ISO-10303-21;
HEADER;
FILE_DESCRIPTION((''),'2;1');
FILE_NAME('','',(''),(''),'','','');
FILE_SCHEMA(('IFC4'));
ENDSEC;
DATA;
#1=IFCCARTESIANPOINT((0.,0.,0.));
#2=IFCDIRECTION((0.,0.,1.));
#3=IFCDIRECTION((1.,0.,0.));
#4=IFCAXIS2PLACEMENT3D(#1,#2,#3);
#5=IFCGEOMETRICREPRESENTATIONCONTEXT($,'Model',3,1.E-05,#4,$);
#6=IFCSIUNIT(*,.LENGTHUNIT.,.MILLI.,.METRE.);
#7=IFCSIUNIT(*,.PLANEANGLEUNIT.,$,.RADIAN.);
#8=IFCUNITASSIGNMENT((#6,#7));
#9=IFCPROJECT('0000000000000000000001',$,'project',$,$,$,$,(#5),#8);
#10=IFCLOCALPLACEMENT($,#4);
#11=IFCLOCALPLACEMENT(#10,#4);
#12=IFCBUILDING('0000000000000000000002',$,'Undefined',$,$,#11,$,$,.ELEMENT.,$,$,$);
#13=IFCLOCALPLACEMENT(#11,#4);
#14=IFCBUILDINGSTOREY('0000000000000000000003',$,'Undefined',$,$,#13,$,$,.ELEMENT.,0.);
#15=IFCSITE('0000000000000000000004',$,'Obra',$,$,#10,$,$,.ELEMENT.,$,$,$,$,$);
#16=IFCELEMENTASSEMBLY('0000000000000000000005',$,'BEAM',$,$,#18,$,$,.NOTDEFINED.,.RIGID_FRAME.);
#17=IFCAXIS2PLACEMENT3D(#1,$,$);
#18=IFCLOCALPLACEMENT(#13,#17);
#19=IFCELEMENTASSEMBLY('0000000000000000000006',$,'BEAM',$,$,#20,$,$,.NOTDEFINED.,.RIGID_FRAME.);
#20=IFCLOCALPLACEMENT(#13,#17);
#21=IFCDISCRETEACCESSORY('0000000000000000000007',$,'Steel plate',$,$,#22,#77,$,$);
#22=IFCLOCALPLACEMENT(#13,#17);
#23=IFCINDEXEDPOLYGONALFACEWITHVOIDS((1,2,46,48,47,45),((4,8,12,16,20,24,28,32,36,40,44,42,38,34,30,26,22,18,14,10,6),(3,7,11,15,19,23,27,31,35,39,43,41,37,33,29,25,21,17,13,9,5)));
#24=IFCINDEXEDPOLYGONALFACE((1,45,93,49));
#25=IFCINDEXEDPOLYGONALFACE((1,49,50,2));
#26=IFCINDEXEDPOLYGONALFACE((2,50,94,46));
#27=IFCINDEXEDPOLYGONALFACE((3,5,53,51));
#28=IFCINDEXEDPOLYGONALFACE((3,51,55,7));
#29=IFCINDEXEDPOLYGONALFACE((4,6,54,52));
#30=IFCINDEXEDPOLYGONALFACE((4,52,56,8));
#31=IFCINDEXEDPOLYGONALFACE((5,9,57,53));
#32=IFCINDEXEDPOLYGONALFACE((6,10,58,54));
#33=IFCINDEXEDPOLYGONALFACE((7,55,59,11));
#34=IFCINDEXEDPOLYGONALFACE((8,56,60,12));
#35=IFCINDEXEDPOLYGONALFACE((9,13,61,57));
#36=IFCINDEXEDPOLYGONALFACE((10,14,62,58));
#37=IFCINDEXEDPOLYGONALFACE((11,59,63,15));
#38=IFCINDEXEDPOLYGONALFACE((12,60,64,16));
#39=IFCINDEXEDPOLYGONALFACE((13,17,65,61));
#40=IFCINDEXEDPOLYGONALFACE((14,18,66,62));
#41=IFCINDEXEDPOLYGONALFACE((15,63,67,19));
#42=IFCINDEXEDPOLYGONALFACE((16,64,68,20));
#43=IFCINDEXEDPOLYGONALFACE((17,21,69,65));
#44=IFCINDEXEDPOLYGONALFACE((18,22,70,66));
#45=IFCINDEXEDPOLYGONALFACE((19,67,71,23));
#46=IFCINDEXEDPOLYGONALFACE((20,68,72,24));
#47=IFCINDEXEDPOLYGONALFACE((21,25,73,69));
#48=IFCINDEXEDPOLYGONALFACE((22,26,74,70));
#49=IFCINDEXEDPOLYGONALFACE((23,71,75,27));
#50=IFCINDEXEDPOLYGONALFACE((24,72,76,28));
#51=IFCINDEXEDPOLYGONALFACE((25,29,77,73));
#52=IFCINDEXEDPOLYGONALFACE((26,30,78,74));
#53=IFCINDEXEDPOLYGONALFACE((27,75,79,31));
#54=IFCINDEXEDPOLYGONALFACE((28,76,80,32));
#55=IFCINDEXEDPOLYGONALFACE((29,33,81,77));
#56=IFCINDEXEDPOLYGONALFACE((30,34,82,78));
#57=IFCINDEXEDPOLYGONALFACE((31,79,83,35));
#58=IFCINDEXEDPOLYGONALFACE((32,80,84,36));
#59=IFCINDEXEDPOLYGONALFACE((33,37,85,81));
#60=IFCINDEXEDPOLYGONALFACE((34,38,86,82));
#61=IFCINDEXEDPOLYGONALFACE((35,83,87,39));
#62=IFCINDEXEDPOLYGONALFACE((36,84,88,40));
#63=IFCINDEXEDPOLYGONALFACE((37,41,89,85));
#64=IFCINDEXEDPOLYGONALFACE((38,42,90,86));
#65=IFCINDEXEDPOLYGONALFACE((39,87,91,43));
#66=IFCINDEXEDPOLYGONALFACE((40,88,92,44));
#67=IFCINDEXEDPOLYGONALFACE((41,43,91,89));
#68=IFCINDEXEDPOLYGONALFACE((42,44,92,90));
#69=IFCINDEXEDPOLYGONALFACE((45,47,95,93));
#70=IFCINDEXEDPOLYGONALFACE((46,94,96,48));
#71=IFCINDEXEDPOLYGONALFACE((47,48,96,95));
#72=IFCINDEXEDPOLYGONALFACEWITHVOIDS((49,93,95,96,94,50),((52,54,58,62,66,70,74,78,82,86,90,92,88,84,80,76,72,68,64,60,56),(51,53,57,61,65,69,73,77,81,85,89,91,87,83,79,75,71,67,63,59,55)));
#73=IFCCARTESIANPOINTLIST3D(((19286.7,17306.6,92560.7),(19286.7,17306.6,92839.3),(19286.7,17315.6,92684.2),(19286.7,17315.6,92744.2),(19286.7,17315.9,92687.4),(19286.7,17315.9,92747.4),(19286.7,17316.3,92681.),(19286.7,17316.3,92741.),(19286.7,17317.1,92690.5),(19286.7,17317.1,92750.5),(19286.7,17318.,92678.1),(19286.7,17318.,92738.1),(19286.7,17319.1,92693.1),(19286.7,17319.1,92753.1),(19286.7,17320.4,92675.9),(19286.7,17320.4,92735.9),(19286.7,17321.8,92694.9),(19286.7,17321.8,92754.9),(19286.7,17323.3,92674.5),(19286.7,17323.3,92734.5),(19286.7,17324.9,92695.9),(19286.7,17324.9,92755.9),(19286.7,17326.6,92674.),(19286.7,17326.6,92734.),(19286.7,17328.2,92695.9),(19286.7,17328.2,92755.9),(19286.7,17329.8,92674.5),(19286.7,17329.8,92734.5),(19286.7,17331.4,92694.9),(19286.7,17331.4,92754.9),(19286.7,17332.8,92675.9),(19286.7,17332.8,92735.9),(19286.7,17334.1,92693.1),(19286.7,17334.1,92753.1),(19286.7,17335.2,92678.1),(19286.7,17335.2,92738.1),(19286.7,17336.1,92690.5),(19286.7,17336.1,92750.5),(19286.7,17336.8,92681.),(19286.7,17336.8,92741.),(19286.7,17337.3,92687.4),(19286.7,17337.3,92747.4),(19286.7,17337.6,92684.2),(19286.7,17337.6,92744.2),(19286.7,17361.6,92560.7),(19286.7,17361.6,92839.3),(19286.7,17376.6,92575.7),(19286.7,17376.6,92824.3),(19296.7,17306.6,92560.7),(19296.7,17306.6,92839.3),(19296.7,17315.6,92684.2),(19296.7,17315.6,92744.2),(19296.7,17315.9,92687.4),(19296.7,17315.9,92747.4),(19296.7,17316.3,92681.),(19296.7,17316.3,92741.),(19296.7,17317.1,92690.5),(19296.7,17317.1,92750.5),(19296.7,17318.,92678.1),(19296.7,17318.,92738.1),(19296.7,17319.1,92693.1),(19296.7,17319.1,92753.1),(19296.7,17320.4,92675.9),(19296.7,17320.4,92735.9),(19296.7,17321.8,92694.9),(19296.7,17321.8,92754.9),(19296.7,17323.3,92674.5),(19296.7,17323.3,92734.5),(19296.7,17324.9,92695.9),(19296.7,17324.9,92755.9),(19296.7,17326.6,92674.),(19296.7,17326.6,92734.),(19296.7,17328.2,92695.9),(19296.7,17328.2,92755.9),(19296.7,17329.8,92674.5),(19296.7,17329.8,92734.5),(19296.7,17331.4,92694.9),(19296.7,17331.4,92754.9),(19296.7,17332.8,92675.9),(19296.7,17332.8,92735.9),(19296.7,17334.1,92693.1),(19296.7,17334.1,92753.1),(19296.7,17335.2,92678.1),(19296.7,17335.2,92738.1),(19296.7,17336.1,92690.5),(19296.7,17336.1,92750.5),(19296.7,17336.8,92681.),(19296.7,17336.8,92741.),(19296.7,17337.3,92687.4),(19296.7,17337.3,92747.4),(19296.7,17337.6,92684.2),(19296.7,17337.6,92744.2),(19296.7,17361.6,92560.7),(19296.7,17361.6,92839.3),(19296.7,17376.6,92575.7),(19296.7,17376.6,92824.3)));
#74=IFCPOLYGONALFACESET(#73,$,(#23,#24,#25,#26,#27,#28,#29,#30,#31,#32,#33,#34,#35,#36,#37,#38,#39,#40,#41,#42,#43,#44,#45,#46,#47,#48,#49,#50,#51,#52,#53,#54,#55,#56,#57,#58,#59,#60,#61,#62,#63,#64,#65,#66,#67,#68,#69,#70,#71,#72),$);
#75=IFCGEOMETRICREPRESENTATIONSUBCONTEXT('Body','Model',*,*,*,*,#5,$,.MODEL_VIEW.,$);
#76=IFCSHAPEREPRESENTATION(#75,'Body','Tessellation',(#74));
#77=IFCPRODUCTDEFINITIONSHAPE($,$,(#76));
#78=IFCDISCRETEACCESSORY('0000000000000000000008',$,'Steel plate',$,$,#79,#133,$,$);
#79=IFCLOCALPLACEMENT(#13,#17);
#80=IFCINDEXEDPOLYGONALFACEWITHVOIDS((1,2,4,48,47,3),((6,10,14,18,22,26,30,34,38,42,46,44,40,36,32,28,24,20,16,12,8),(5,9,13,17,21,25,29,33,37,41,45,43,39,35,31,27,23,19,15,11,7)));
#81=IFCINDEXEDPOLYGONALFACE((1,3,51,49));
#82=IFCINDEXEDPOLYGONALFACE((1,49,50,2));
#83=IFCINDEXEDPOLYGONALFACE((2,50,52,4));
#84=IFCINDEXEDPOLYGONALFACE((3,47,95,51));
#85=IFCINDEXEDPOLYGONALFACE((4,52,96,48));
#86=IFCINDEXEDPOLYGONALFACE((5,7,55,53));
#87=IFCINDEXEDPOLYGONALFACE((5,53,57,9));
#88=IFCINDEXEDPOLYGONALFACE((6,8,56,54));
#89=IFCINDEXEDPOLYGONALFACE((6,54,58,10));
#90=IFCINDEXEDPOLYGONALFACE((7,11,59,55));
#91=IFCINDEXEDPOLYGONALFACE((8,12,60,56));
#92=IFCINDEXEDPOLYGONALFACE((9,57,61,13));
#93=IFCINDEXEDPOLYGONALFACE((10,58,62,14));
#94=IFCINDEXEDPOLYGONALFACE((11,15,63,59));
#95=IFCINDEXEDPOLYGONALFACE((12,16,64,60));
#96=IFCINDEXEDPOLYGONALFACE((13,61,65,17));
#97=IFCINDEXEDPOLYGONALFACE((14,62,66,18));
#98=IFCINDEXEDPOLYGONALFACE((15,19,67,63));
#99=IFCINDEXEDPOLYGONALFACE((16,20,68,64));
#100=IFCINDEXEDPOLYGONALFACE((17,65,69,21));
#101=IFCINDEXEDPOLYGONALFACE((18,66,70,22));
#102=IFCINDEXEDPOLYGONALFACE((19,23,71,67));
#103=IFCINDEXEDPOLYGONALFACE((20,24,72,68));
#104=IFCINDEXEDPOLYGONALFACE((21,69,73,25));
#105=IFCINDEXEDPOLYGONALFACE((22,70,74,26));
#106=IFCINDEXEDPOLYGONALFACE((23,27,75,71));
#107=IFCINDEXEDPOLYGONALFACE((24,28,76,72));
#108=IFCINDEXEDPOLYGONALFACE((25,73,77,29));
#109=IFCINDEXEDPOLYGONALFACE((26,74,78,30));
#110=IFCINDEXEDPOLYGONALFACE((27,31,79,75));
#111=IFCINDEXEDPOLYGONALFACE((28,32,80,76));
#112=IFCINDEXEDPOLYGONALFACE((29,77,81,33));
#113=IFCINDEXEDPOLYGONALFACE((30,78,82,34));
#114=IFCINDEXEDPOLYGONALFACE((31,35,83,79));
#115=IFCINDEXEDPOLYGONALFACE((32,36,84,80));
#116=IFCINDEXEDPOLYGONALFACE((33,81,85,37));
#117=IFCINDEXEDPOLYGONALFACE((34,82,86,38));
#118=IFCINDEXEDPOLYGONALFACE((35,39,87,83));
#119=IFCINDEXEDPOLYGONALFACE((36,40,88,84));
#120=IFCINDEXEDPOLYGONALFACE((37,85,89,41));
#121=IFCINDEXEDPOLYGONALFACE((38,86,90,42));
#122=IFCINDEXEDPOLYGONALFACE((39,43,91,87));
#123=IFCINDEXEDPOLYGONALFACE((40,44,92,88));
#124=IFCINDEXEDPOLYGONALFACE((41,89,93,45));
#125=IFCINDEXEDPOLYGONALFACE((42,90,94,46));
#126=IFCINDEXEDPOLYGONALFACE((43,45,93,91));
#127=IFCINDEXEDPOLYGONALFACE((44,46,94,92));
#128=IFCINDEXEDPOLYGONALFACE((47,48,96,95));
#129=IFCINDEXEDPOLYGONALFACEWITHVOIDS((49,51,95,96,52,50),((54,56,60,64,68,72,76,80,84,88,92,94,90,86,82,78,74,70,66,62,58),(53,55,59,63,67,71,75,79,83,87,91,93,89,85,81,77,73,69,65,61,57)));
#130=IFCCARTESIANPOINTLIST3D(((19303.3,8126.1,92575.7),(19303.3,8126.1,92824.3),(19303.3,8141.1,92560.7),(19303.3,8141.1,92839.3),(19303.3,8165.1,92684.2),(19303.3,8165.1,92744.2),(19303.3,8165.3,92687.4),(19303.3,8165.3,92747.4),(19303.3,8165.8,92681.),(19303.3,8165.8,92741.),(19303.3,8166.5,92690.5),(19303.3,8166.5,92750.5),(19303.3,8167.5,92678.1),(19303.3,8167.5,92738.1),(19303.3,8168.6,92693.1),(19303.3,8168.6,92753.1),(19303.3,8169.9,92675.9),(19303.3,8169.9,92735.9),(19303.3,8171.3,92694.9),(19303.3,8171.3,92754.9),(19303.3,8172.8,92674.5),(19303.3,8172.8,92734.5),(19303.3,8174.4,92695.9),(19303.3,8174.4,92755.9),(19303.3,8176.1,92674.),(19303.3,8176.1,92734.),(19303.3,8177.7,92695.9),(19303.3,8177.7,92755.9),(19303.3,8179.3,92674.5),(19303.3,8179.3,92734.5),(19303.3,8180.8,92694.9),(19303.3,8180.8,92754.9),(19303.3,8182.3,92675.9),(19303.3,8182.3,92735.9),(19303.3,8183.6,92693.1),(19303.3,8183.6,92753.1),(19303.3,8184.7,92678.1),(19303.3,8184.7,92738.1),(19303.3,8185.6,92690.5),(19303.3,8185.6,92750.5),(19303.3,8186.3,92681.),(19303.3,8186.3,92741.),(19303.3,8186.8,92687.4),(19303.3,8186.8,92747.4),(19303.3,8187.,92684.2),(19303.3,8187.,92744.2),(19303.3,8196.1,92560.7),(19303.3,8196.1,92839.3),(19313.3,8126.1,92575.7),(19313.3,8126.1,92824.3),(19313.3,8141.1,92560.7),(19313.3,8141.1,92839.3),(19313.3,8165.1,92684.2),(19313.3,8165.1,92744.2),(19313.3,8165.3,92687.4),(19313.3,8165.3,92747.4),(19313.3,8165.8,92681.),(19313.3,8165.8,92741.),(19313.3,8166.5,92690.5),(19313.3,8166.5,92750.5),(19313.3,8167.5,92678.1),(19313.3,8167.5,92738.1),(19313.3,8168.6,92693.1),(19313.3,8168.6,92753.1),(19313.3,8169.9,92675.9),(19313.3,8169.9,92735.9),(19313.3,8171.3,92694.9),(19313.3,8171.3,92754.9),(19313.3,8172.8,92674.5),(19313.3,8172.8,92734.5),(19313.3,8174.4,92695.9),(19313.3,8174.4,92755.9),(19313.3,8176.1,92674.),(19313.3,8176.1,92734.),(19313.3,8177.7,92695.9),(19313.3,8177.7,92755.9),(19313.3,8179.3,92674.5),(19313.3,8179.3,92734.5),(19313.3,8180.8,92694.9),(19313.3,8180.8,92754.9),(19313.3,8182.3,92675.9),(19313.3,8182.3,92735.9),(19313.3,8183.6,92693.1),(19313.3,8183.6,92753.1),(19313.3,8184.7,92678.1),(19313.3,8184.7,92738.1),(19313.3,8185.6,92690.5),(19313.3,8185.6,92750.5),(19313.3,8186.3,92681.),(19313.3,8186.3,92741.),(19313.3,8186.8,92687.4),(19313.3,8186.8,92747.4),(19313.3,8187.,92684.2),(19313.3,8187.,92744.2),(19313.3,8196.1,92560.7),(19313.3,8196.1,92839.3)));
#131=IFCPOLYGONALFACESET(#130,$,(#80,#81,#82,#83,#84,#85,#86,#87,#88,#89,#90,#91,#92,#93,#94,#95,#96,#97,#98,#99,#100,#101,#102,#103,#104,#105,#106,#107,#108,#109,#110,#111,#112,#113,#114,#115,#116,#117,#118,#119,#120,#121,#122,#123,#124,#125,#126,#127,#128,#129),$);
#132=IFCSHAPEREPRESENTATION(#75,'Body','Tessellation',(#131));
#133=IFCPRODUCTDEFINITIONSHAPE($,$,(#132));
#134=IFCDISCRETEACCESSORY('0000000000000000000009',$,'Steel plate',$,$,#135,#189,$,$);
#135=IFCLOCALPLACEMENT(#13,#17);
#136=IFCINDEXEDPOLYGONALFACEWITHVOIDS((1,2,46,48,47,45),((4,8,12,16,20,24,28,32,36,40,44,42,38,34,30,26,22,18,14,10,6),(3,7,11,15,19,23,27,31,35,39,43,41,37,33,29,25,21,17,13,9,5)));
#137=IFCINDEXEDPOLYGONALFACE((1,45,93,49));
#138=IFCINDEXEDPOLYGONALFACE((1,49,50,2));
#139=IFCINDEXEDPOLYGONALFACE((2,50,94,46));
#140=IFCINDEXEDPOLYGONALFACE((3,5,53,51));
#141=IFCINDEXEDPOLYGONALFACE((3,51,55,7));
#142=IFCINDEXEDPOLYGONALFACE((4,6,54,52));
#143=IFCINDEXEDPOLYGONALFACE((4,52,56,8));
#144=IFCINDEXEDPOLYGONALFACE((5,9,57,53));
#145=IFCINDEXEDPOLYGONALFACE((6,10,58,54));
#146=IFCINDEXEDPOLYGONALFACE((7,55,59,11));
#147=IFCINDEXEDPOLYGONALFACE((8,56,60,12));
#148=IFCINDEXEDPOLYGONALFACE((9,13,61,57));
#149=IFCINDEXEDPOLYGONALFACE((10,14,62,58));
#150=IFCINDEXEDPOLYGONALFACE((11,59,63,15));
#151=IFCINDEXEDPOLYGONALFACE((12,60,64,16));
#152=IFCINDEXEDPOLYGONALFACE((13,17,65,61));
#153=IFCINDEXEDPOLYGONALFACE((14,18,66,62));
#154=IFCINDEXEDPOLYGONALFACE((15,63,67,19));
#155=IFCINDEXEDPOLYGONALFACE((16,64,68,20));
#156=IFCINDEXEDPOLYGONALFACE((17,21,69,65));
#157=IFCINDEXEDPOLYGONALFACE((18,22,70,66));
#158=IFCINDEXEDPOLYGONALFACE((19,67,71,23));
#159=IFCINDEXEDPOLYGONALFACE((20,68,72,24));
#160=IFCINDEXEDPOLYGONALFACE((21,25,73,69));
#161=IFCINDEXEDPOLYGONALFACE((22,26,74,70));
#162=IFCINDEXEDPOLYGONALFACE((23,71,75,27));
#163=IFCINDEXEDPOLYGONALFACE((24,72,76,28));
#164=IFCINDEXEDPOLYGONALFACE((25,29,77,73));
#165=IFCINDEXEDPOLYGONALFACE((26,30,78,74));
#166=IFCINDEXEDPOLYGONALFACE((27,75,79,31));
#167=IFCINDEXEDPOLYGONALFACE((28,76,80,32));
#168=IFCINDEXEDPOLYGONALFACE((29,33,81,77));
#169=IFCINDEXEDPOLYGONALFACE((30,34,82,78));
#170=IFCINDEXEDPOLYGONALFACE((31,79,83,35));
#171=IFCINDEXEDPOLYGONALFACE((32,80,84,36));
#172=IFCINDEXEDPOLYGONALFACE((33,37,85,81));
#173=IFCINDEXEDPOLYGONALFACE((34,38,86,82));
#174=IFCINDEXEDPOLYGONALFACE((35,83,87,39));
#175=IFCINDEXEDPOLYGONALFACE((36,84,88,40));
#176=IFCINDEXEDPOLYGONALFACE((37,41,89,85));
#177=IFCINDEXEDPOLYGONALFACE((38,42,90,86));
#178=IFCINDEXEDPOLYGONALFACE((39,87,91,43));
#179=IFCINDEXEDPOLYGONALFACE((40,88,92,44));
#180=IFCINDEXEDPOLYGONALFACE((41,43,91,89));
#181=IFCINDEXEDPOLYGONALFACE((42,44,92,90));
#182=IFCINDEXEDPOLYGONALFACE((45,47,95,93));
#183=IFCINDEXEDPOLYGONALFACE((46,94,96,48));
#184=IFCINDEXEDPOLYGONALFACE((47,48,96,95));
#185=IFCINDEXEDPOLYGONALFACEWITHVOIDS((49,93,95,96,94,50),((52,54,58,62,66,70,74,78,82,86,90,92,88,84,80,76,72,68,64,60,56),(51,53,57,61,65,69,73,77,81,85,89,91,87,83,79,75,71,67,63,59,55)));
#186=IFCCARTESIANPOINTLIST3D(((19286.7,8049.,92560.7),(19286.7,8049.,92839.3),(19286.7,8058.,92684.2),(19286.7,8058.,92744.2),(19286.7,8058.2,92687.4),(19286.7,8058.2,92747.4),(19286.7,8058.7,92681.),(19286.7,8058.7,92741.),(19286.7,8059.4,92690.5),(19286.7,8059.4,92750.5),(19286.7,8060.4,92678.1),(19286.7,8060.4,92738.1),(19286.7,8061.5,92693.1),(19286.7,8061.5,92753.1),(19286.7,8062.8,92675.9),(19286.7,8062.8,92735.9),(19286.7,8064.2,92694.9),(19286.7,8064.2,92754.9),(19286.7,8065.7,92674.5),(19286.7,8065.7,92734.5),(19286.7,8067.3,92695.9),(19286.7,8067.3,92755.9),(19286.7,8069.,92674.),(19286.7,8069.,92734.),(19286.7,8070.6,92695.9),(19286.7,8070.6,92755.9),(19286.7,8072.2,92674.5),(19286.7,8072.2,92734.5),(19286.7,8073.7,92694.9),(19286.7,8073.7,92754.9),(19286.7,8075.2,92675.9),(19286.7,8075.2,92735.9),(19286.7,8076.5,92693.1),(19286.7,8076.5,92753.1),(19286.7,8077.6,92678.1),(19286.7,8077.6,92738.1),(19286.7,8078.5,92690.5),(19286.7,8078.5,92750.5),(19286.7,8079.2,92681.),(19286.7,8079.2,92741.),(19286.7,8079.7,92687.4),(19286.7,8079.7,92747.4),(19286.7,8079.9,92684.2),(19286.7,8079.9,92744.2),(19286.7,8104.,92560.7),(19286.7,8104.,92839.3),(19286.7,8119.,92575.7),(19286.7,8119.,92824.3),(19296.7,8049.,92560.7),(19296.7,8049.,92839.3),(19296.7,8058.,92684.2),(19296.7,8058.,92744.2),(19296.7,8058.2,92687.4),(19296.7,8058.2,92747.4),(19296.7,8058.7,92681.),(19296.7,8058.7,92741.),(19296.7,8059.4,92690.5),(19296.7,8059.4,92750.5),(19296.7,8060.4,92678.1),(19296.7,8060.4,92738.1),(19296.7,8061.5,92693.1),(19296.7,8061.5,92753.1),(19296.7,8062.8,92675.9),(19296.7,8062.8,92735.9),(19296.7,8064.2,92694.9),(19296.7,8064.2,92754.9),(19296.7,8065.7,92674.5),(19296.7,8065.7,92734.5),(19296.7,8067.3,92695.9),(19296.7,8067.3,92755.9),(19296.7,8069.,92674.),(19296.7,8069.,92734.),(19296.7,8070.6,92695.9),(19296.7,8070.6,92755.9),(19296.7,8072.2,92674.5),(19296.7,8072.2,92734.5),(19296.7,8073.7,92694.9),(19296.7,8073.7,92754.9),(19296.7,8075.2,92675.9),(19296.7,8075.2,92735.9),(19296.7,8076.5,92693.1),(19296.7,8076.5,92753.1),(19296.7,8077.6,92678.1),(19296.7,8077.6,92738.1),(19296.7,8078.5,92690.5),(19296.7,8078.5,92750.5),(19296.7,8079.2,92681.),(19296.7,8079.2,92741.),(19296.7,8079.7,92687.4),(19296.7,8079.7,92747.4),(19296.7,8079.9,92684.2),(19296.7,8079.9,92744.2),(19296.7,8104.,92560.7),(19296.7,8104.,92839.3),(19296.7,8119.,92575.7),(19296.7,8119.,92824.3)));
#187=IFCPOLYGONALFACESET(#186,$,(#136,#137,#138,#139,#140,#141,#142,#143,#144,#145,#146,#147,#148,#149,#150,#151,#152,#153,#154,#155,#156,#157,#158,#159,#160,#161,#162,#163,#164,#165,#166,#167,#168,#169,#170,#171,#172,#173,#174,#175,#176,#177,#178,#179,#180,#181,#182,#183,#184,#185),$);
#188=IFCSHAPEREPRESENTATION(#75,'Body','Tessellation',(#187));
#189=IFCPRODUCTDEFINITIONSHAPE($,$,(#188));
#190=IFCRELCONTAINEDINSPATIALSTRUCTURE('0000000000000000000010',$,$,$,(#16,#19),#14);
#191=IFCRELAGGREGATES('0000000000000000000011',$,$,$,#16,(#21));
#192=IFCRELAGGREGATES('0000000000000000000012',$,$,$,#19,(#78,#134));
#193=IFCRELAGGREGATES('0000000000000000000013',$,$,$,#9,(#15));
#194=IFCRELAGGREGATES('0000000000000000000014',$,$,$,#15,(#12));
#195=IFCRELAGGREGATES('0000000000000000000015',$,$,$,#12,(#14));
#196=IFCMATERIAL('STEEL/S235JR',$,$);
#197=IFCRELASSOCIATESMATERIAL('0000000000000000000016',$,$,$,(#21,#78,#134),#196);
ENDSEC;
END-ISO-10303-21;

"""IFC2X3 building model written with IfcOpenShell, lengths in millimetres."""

from ifc_helpers import new_model, si_unit, frame, origin_with_axes, origin_2d_with_axis, place, context, subcontext, project, spatial, polyline, circle, outline, extrude, source, transform, mapped, material, element, aggregate, save


model = new_model("IFC2X3")

# Units and contexts
model_context = context("Model", 3, precision=1e-05, world=origin_with_axes())
body_context = subcontext(model_context, "Body", "Model", "MODEL_VIEW")
ifc_project = project(units=[si_unit("LENGTHUNIT", "METRE", prefix="MILLI"), si_unit("PLANEANGLEUNIT", "RADIAN")], contexts=[model_context])

# Site, building, storey
site_placement = place(None, origin_with_axes())
site = spatial("IfcSite", under=ifc_project, at=site_placement, Name="Obra", CompositionType="ELEMENT")
building_placement = place(site_placement, origin_with_axes())
building = spatial("IfcBuilding", under=site, at=building_placement, Name="Undefined", CompositionType="ELEMENT")
storey_placement = place(building_placement, origin_with_axes())
storey = spatial("IfcBuildingStorey", under=building, at=storey_placement, Name="Undefined", CompositionType="ELEMENT", Elevation=0.0)

# Element assemblies
assembly_1_placement = place(storey_placement, origin_with_axes())
assembly_1 = element("IfcElementAssembly", 1, at=assembly_1_placement, inside=storey, Name="BEAM", AssemblyPlace="NOTDEFINED", PredefinedType="RIGID_FRAME")
ifc_material_1 = material(Name="STEEL/S235JR")
assembly_2_placement = place(storey_placement, origin_with_axes())
assembly_2 = element("IfcElementAssembly", 2, at=assembly_2_placement, inside=storey, Name="BEAM", AssemblyPlace="NOTDEFINED", PredefinedType="RIGID_FRAME")

# Discrete accessories, openings
shared_shape_1 = source(origin_with_axes(), body_context, "Body", "SweptSolid", [
    extrude(circle(Radius=11.0, at=origin_2d_with_axis()), frame((0.0, -13.4, 0.0), z_axis=(0.0, 1.0, 0.0), x_axis=(1.0, 0.0, 0.0)), (0.0, 0.0, 1.0), 10.2),
])
discrete_accessory_1_placement = place(assembly_1_placement, frame((19291.7, 17306.6, 92560.7), z_axis=(1.0, 0.0, 0.0), x_axis=(0.0, 1.0, 0.0)))
discrete_accessory_1 = element("IfcDiscreteAccessory", 3, at=discrete_accessory_1_placement, material=ifc_material_1, Name="Steel plate", context=body_context, shape_type="SweptSolid", body=[
    extrude(outline(polyline([(0.0, 0.0), (55.0, 0.0), (70.0, 15.0), (70.0, 263.6), (55.0, 278.6), (0.0, 278.6), (0.0, 0.0)])), frame((0.0, 0.0, -5.0), z_axis=(0.0, 0.0, 1.0), x_axis=(1.0, 0.0, 0.0)), (0.0, 0.0, 1.0), 10.0),
])
opening_1_placement = place(assembly_1_placement, frame((19300.0, 17366.6, 92850.0), z_axis=(0.0, -1.0, 0.0), x_axis=(0.0, 0.0, -1.0)))
element("IfcOpeningElement", 4, at=opening_1_placement, cuts=discrete_accessory_1, ObjectType="Opening", context=body_context, shape_type="MappedRepresentation", body=[
    mapped(shared_shape_1, transform((105.0, 0.0, 40.0))),
    mapped(shared_shape_1, transform((165.0, 0.0, 40.0))),
])
aggregate(assembly_1, [discrete_accessory_1])
discrete_accessory_2_placement = place(assembly_2_placement, frame((19308.3, 8196.1, 92560.7), z_axis=(-1.0, 0.0, 0.0), x_axis=(0.0, -1.0, 0.0)))
discrete_accessory_2 = element("IfcDiscreteAccessory", 5, at=discrete_accessory_2_placement, material=ifc_material_1, Name="Steel plate", context=body_context, shape_type="SweptSolid", body=[
    extrude(outline(polyline([(0.0, 0.0), (55.0, 0.0), (70.0, 15.0), (70.0, 263.6), (55.0, 278.6), (0.0, 278.6), (0.0, 0.0)])), frame((0.0, 0.0, -5.0), z_axis=(0.0, 0.0, 1.0), x_axis=(1.0, 0.0, 0.0)), (0.0, 0.0, 1.0), 10.0),
])
opening_2_placement = place(assembly_2_placement, frame((19300.0, 8136.1, 92850.0), z_axis=(0.0, 1.0, 0.0), x_axis=(0.0, 0.0, -1.0)))
element("IfcOpeningElement", 6, at=opening_2_placement, cuts=discrete_accessory_2, ObjectType="Opening", context=body_context, shape_type="MappedRepresentation", body=[
    mapped(shared_shape_1, transform((105.0, 0.0, 40.0))),
    mapped(shared_shape_1, transform((165.0, 0.0, 40.0))),
])
discrete_accessory_3_placement = place(assembly_2_placement, frame((19291.7, 8049.0, 92560.7), z_axis=(1.0, 0.0, 0.0), x_axis=(0.0, 1.0, 0.0)))
discrete_accessory_3 = element("IfcDiscreteAccessory", 7, at=discrete_accessory_3_placement, material=ifc_material_1, Name="Steel plate", context=body_context, shape_type="SweptSolid", body=[
    extrude(outline(polyline([(0.0, 0.0), (55.0, 0.0), (70.0, 15.0), (70.0, 263.6), (55.0, 278.6), (0.0, 278.6), (0.0, 0.0)])), frame((0.0, 0.0, -5.0), z_axis=(0.0, 0.0, 1.0), x_axis=(1.0, 0.0, 0.0)), (0.0, 0.0, 1.0), 10.0),
])
opening_3_placement = place(assembly_2_placement, frame((19300.0, 8109.0, 92850.0), z_axis=(0.0, -1.0, 0.0), x_axis=(0.0, 0.0, -1.0)))
element("IfcOpeningElement", 8, at=opening_3_placement, cuts=discrete_accessory_3, ObjectType="Opening", context=body_context, shape_type="MappedRepresentation", body=[
    mapped(shared_shape_1, transform((105.0, 0.0, 40.0))),
    mapped(shared_shape_1, transform((165.0, 0.0, 40.0))),
])
aggregate(assembly_2, [discrete_accessory_2, discrete_accessory_3])

save(model, "model.ifc")
